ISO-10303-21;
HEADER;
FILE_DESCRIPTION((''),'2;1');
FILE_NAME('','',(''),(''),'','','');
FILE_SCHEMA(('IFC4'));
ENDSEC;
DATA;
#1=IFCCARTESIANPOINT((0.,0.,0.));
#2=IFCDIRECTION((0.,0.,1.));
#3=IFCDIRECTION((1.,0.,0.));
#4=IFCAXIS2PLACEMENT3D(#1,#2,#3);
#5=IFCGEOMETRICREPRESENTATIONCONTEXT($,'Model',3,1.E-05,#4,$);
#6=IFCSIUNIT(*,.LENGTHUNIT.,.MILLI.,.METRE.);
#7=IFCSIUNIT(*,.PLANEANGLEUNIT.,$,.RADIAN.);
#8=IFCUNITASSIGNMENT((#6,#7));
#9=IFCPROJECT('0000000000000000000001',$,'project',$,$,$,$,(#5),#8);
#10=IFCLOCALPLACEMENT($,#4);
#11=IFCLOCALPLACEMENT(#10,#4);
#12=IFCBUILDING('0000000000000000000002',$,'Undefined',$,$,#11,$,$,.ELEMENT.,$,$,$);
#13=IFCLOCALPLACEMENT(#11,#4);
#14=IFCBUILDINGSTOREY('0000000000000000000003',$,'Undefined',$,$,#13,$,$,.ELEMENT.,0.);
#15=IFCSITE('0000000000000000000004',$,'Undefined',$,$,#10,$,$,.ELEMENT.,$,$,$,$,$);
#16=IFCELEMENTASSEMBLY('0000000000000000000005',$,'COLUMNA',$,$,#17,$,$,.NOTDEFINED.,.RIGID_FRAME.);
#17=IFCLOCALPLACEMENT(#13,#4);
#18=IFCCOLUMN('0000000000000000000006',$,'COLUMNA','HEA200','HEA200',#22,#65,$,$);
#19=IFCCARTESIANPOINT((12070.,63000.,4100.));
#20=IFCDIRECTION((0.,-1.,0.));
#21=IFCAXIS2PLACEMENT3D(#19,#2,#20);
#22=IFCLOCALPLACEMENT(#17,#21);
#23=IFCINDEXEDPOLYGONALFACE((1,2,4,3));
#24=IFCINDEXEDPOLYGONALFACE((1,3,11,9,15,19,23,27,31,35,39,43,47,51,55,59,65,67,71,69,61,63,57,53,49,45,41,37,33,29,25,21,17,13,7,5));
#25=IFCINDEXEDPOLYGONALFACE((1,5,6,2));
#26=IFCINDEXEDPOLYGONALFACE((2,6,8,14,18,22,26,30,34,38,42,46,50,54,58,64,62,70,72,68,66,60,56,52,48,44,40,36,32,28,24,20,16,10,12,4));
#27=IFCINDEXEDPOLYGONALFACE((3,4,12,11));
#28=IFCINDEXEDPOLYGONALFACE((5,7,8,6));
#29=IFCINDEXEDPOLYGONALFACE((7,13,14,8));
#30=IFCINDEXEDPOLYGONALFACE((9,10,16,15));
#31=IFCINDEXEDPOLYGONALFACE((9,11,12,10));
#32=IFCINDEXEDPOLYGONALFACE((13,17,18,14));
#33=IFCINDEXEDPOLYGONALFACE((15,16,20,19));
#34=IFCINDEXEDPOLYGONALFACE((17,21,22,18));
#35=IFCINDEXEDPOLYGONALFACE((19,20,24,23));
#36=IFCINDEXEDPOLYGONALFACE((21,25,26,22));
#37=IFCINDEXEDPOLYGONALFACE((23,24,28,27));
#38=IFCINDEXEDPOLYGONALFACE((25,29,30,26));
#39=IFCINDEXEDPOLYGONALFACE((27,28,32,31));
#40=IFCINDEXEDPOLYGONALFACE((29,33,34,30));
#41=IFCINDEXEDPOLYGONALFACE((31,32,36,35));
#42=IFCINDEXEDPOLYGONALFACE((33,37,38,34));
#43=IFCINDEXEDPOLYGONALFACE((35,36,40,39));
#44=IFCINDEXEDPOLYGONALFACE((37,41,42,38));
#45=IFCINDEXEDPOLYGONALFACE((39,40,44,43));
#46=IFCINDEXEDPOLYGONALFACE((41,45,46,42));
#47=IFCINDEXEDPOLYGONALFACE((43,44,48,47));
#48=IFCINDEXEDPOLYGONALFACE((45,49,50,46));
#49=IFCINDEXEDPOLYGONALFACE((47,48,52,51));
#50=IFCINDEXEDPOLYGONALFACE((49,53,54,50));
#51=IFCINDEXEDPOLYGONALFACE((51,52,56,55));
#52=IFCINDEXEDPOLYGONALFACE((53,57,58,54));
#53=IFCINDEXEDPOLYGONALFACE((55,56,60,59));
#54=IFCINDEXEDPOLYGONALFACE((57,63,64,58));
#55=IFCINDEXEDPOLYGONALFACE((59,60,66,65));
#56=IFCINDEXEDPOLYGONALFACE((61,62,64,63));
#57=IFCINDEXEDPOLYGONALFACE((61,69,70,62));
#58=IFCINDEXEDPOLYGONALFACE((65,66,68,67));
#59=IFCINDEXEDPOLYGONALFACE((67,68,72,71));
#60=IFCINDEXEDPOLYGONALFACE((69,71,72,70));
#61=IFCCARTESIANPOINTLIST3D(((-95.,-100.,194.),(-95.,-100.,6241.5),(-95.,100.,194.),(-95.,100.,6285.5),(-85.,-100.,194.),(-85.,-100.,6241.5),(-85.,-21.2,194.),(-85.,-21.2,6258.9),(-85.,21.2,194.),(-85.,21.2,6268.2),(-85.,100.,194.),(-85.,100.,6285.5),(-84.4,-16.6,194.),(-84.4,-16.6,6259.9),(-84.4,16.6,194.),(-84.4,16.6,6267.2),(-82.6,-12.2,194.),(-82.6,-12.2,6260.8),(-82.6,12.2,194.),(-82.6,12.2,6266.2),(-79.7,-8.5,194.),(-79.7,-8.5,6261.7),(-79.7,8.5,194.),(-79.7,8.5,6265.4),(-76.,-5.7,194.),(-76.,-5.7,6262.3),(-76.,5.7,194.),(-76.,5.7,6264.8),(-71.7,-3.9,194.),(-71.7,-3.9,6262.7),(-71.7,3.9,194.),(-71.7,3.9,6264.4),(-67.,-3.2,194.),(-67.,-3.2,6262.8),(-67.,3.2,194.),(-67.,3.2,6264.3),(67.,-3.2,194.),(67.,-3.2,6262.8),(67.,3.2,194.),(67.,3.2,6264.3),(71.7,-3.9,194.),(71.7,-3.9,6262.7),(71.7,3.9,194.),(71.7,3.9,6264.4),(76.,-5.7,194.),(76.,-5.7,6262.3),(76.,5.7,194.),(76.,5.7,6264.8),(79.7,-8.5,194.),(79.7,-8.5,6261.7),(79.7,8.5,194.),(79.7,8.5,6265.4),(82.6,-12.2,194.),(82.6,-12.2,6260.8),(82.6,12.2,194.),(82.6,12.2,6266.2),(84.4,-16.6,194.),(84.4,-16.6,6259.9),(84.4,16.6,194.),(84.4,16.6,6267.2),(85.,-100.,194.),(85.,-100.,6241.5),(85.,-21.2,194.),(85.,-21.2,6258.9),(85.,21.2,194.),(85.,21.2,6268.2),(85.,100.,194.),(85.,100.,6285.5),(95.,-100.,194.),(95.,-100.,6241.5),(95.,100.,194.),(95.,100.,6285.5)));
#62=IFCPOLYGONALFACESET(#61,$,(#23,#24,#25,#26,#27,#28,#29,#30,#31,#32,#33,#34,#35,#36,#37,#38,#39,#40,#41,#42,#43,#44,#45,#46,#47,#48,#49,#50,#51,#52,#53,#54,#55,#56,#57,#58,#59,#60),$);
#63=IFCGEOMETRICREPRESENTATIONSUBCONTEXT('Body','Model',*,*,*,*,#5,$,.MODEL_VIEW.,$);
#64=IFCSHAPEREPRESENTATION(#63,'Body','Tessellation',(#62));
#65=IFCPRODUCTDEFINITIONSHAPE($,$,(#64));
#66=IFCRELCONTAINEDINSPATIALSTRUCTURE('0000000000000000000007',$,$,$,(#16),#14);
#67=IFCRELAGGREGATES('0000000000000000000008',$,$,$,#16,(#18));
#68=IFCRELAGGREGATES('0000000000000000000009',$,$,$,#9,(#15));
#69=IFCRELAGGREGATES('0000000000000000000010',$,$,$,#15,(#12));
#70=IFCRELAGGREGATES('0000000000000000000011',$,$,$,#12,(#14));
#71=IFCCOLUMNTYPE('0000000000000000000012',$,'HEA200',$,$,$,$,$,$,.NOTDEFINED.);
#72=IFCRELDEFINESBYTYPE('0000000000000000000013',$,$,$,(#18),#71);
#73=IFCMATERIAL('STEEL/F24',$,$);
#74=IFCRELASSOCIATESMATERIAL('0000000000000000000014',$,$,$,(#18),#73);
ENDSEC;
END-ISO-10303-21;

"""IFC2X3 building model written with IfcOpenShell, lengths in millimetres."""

from ifc_helpers import new_model, si_unit, frame, origin_with_axes, origin_2d_with_axis, place, context, subcontext, project, spatial, i_section, extrude, clip, halfspace, material, type_object, element, aggregate, save


model = new_model("IFC2X3")

# Units and contexts
model_context = context("Model", 3, precision=1e-05, world=origin_with_axes())
body_context = subcontext(model_context, "Body", "Model", "MODEL_VIEW")
ifc_project = project(units=[si_unit("LENGTHUNIT", "METRE", prefix="MILLI"), si_unit("PLANEANGLEUNIT", "RADIAN")], contexts=[model_context])

# Site, building, storey
site_placement = place(None, origin_with_axes())
site = spatial("IfcSite", under=ifc_project, at=site_placement, Name="Undefined", CompositionType="ELEMENT")
building_placement = place(site_placement, origin_with_axes())
building = spatial("IfcBuilding", under=site, at=building_placement, Name="Undefined", CompositionType="ELEMENT")
storey_placement = place(building_placement, origin_with_axes())
storey = spatial("IfcBuildingStorey", under=building, at=storey_placement, Name="Undefined", CompositionType="ELEMENT", Elevation=0.0)

# Element assembly, column
assembly_1_placement = place(storey_placement, origin_with_axes())
assembly_1 = element("IfcElementAssembly", 1, at=assembly_1_placement, inside=storey, Name="COLUMNA", AssemblyPlace="NOTDEFINED", PredefinedType="RIGID_FRAME")
ifc_material_1 = material(Name="STEEL/F24")
column_type = type_object("IfcColumnType", Name="HEA200", PredefinedType="NOTDEFINED")
column_placement = place(assembly_1_placement, frame((12070.0, 63000.0, 4100.0), z_axis=(0.0, 0.0, 1.0), x_axis=(0.0, -1.0, 0.0)))
column = element("IfcColumn", 2, at=column_placement, type_object=column_type, material=ifc_material_1, Name="COLUMNA", Description="HEA200", ObjectType="HEA200", context=body_context, shape_type="Clipping", body=[
    clip(clip(extrude(i_section(OverallWidth=200.0, OverallDepth=190.0, WebThickness=6.5, FlangeThickness=10.0, FilletRadius=18.0, at=origin_2d_with_axis()), frame((0.0, 0.0, 6285.8), z_axis=(0.0, 0.0, -1.0), x_axis=(0.0, 1.0, 0.0)), (0.0, 0.0, 1.0), 6113.9), halfspace(frame((0.0, -100.0, 6241.5), z_axis=(0.0, 0.214887, -0.976639), x_axis=(1.0, 0.0, 0.0)), True)), halfspace(frame((-95.0, 0.0, 194.0), z_axis=(0.0, 0.0, 1.0), x_axis=(0.0, 1.0, 0.0)), True)),
])

aggregate(assembly_1, [column])

save(model, "model.ifc")
